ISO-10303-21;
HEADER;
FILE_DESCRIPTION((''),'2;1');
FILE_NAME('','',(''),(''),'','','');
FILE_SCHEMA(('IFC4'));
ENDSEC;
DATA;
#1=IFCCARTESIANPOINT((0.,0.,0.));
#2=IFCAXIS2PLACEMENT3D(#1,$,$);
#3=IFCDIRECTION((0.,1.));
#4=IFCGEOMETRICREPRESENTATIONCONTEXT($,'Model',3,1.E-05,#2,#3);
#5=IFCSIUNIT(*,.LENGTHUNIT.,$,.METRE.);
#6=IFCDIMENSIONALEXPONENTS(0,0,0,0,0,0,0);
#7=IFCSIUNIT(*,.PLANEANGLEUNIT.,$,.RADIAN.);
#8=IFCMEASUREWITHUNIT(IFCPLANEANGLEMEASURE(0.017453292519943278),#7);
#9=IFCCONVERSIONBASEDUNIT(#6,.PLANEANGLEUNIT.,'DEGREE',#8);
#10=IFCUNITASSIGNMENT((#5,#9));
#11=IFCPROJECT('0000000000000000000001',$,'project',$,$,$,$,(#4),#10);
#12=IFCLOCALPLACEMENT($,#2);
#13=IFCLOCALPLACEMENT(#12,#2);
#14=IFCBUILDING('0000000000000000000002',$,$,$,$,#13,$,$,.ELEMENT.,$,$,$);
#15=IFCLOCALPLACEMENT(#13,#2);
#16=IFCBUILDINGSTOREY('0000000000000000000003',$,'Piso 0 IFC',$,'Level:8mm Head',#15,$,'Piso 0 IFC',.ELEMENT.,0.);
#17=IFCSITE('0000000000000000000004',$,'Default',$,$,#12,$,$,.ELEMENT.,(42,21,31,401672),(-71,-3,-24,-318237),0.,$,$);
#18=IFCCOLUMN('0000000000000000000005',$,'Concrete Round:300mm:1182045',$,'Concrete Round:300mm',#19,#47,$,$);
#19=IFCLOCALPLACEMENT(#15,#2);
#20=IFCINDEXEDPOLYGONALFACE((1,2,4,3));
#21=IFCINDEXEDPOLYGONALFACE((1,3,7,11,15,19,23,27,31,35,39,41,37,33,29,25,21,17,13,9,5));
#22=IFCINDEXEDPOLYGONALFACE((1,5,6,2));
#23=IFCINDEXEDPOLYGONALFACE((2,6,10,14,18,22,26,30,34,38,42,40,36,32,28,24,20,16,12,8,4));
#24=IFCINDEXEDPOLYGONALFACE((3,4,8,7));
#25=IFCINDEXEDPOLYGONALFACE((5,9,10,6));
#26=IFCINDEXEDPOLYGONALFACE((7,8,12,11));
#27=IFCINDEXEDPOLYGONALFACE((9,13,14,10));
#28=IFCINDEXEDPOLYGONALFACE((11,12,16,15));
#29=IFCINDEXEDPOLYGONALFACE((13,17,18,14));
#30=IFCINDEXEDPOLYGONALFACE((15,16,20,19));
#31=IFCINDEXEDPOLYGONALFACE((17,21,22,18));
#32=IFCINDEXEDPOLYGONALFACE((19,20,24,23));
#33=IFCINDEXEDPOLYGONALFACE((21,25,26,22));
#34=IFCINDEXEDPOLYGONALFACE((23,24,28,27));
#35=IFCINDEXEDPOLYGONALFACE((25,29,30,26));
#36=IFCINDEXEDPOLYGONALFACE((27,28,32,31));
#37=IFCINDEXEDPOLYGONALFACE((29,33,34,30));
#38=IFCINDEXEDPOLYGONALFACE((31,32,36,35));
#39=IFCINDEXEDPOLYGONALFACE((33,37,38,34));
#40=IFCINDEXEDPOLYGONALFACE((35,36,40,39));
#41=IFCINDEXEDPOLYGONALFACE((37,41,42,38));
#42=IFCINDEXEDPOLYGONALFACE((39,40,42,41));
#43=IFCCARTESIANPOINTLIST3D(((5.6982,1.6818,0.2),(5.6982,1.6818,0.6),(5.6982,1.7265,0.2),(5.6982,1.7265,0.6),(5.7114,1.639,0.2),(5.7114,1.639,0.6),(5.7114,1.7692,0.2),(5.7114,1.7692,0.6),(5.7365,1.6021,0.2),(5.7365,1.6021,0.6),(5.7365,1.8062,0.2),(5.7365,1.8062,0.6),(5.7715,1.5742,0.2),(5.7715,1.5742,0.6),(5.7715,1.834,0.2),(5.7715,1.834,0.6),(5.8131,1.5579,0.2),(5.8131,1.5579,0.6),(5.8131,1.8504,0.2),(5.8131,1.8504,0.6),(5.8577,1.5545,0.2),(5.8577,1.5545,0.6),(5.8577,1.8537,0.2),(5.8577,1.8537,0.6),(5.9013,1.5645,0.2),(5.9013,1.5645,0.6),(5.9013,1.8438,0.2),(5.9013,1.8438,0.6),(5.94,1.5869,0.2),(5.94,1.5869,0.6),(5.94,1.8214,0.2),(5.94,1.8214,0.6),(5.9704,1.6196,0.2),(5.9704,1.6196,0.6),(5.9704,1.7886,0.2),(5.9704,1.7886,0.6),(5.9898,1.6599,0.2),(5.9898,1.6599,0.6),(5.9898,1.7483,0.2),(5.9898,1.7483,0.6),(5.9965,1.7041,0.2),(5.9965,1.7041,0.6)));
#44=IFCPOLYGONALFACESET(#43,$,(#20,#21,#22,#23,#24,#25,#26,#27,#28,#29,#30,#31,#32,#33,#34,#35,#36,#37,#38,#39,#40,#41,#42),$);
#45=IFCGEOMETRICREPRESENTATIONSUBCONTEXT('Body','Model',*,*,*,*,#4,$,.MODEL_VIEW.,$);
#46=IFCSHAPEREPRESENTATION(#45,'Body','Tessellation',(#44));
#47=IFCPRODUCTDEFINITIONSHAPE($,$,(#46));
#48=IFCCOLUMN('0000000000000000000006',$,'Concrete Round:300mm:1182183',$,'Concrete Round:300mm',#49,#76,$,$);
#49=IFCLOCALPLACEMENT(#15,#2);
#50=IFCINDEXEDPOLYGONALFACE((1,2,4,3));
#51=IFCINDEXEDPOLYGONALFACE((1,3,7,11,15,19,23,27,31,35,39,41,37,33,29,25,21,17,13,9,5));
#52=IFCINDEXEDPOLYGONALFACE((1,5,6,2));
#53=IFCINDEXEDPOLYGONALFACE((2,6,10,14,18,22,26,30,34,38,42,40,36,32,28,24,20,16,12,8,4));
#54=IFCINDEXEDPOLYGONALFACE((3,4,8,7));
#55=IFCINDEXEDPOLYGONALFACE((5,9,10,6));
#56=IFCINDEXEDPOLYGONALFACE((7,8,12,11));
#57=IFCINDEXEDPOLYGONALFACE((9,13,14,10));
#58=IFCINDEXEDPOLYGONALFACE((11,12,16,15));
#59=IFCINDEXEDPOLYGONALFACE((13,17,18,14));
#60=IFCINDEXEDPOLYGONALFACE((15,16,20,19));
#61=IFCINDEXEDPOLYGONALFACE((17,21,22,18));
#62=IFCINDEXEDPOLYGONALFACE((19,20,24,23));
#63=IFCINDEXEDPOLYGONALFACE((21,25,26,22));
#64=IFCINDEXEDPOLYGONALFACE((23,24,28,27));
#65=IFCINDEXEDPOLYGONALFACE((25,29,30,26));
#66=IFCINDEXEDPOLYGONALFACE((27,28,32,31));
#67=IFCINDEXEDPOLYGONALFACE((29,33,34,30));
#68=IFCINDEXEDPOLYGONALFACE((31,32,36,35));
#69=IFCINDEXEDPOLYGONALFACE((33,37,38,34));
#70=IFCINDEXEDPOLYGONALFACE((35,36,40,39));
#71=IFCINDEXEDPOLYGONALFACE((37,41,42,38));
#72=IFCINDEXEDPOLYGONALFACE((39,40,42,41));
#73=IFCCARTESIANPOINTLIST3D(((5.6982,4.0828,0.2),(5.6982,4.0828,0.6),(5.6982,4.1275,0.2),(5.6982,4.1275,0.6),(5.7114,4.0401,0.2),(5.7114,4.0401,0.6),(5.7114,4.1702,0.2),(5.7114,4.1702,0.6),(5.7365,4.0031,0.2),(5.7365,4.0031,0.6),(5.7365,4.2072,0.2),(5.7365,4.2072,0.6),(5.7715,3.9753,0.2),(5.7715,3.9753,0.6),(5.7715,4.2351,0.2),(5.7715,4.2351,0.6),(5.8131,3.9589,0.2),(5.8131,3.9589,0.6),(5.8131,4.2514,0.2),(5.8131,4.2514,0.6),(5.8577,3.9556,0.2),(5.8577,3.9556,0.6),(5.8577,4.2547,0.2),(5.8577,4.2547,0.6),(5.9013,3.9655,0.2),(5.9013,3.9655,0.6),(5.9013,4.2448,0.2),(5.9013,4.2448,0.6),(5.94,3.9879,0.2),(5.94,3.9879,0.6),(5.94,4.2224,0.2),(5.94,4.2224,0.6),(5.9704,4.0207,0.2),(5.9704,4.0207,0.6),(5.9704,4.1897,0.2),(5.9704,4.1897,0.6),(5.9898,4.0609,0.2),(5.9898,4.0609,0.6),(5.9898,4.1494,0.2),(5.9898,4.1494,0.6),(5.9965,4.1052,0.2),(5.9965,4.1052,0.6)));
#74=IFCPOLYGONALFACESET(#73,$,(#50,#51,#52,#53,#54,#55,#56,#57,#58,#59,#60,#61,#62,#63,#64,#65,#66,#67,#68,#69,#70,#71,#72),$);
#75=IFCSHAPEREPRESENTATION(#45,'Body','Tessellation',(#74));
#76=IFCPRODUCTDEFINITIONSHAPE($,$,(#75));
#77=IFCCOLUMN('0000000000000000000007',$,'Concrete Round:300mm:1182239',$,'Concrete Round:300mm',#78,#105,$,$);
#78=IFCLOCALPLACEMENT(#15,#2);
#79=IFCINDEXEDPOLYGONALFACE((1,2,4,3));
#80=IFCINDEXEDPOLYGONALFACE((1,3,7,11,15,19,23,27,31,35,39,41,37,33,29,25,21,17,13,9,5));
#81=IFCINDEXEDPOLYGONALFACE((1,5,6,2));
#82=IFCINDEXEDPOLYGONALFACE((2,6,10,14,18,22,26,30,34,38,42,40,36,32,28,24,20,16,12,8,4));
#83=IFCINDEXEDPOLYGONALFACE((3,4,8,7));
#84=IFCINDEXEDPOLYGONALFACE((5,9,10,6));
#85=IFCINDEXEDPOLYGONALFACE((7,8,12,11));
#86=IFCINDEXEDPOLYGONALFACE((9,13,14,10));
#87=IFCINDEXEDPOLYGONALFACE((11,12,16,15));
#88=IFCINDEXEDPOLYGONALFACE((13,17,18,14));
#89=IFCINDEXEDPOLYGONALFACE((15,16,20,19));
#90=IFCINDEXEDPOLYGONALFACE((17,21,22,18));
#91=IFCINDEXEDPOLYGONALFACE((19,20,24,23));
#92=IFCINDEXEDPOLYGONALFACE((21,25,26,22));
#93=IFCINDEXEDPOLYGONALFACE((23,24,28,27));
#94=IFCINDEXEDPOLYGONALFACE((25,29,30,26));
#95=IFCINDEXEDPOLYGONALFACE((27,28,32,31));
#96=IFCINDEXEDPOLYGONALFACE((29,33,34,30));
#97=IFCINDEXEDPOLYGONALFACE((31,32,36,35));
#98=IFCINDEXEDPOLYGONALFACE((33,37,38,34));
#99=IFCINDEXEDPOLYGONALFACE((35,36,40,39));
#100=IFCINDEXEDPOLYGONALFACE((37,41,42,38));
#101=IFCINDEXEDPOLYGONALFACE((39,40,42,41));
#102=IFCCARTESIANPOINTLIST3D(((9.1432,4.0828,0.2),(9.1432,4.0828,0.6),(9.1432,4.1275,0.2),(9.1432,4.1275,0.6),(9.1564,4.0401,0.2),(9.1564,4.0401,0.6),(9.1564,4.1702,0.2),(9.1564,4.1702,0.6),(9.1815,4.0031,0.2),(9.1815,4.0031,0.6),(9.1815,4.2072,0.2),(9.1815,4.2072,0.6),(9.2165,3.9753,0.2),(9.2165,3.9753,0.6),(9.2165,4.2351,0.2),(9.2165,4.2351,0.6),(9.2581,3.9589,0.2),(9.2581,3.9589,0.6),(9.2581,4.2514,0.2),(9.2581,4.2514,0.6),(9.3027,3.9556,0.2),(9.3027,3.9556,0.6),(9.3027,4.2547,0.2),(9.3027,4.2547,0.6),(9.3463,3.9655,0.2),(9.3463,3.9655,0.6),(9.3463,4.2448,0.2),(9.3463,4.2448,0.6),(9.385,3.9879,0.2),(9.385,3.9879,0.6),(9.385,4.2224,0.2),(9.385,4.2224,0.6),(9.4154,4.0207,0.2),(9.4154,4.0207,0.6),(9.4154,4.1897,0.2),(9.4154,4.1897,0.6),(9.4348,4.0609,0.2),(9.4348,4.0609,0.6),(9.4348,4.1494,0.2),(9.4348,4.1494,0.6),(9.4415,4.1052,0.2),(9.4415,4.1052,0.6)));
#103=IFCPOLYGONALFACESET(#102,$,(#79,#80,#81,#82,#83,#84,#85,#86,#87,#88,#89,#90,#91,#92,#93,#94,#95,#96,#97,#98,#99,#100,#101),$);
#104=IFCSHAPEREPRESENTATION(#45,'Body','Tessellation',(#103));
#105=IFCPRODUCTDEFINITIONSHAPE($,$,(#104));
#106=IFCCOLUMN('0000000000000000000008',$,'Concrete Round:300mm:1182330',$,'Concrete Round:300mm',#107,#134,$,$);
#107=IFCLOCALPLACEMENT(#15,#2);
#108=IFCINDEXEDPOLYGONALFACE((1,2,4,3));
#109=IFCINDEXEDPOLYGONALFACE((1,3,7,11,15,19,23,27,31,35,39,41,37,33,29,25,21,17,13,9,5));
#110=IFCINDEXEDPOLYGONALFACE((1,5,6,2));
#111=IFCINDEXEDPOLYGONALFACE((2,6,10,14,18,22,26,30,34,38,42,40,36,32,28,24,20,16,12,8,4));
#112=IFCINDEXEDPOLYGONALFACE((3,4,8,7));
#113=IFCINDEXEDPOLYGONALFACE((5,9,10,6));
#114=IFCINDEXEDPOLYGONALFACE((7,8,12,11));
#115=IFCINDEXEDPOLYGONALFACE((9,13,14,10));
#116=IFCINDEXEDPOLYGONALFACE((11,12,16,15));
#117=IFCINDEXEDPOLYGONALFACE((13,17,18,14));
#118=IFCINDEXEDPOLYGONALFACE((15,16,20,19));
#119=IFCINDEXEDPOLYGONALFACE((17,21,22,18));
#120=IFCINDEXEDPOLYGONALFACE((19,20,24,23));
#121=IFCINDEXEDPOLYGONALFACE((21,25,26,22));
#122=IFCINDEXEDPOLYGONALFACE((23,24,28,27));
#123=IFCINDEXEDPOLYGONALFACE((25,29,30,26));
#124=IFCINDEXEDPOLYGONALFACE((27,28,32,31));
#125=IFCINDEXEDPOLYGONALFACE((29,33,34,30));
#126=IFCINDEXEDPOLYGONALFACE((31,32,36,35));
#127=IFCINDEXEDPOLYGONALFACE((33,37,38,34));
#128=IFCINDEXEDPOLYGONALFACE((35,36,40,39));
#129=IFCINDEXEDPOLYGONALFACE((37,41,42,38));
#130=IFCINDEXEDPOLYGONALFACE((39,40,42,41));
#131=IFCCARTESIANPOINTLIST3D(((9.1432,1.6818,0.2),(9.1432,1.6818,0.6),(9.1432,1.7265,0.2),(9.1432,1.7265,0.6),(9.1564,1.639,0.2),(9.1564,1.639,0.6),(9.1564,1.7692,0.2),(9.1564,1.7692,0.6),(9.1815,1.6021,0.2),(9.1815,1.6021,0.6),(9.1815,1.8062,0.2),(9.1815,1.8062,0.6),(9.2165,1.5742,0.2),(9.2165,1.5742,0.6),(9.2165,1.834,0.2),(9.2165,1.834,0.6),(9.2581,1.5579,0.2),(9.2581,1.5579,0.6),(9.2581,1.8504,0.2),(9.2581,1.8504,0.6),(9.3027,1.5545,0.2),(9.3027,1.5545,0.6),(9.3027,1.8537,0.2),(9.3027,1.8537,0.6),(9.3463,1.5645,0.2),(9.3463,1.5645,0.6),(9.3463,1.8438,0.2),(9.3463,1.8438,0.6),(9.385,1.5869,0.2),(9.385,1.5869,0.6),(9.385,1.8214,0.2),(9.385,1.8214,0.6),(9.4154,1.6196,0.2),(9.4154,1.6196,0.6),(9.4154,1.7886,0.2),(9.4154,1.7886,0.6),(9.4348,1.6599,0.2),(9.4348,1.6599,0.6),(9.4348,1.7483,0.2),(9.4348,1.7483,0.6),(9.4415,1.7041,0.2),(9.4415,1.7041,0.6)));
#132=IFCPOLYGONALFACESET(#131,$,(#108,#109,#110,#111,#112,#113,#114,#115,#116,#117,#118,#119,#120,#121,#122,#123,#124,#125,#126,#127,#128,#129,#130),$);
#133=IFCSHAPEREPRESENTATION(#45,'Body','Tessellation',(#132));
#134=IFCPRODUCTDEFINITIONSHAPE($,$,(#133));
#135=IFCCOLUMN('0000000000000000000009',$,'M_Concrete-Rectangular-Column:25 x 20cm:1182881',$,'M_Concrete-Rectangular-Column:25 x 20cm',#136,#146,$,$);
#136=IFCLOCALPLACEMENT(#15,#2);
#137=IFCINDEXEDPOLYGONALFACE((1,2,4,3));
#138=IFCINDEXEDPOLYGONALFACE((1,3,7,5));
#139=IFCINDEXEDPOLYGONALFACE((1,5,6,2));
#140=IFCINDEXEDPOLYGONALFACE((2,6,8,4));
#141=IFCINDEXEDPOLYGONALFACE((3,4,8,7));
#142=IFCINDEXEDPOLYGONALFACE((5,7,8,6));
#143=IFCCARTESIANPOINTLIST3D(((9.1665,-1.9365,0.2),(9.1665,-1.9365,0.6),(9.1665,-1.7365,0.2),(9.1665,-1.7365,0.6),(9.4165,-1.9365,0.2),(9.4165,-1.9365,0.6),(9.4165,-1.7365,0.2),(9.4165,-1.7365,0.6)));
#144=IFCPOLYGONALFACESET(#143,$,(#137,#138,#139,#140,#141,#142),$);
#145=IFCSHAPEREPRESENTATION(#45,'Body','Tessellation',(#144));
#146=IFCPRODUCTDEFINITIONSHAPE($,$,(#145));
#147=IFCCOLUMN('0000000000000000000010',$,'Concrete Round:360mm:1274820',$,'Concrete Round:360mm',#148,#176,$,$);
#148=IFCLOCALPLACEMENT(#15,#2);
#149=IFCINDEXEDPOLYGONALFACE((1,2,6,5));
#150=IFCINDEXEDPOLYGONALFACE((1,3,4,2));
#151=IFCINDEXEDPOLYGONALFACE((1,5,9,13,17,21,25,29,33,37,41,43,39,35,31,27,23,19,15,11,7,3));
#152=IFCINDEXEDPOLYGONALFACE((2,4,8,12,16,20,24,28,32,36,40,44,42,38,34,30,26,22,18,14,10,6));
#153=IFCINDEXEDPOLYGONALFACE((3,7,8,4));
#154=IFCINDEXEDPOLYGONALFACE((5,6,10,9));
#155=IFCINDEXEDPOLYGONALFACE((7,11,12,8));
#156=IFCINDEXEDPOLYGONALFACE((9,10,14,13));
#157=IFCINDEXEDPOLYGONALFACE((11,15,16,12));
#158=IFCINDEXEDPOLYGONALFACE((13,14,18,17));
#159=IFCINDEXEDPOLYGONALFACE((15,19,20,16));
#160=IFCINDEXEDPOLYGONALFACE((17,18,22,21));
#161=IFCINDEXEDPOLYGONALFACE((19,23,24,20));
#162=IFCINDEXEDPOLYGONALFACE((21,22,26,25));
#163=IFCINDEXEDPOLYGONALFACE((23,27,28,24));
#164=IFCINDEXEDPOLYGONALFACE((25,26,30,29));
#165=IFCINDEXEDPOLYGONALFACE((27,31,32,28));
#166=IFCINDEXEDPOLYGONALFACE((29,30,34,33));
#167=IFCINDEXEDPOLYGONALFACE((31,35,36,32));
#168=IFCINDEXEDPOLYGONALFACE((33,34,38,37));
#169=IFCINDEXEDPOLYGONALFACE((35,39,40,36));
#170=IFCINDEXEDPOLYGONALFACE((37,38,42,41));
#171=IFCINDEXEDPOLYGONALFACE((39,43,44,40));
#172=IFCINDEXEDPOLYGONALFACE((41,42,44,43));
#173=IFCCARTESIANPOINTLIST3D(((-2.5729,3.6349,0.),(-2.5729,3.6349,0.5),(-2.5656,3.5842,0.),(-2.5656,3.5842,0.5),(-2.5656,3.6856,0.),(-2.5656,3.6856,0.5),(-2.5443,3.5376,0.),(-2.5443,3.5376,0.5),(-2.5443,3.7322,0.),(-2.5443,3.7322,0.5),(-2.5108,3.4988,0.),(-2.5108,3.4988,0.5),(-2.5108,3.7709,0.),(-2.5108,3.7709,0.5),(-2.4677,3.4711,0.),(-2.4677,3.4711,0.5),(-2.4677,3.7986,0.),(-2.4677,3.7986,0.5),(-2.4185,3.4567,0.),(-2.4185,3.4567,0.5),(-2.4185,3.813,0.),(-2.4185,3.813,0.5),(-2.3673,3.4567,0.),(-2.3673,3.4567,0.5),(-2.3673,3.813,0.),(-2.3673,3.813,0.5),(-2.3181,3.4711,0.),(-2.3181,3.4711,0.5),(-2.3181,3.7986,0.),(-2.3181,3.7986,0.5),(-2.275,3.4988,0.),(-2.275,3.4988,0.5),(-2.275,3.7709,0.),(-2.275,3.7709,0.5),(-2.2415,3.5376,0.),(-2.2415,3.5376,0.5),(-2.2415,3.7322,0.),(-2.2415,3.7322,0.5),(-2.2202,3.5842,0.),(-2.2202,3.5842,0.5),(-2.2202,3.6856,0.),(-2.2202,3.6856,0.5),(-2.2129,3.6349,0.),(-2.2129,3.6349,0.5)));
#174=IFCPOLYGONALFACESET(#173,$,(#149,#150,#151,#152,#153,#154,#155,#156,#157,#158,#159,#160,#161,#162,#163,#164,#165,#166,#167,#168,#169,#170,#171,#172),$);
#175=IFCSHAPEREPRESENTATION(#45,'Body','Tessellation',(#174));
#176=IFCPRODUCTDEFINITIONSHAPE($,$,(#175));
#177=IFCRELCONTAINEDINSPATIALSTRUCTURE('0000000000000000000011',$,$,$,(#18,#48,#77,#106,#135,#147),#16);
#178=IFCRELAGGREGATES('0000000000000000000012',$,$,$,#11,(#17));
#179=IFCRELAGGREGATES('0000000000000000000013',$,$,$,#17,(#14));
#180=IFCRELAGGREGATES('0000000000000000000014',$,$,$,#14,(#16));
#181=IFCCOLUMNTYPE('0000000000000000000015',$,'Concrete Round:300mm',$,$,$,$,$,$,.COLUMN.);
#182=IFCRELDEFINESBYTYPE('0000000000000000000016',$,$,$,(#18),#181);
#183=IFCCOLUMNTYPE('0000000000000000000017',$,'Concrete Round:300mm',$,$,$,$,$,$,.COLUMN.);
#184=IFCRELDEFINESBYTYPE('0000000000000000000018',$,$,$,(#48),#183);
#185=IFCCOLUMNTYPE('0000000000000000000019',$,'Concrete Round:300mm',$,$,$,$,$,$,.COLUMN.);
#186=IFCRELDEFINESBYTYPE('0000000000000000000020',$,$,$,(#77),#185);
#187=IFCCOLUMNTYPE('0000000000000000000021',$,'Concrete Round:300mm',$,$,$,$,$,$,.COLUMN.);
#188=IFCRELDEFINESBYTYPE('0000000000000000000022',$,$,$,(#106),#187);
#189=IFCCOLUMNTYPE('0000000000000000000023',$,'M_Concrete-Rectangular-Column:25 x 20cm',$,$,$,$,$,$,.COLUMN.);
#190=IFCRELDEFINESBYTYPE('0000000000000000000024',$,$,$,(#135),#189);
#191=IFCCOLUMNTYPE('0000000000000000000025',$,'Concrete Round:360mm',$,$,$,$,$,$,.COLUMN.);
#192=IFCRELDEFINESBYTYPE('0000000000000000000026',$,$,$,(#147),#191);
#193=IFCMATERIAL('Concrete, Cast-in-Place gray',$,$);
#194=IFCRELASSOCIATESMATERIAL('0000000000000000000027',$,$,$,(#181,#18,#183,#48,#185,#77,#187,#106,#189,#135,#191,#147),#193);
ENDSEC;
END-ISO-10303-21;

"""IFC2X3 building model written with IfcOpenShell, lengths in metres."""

from ifc_helpers import new_model, entity, si_unit, converted_unit, direction, frame, frame_2d, origin, origin_2d_with_axis, place, context, subcontext, project, spatial, rectangle, circle, extrude, source, transform, mapped, material, type_object, type_shapes, element, save


model = new_model("IFC2X3")

# Units and contexts
model_context = context("Model", 3, precision=1e-05, world=origin(), true_north=direction((0.0, 1.0)))
body_context = subcontext(model_context, "Body", "Model", "MODEL_VIEW")
ifc_project = project(units=[si_unit("LENGTHUNIT", "METRE"), converted_unit("PLANEANGLEUNIT", "DEGREE", entity("IfcPlaneAngleMeasure", 0.017453292519943278), si_unit("PLANEANGLEUNIT", "RADIAN"), dimensions=[0, 0, 0, 0, 0, 0, 0])], contexts=[model_context])

# Site, building, storey
site_placement = place(None, origin())
site = spatial("IfcSite", under=ifc_project, at=site_placement, Name="Default", CompositionType="ELEMENT", RefLatitude=(42, 21, 31, 401672), RefLongitude=(-71, -3, -24, -318237), RefElevation=0.0)
building_placement = place(site_placement, origin())
building = spatial("IfcBuilding", under=site, at=building_placement, CompositionType="ELEMENT")
storey_placement = place(building_placement, origin())
storey = spatial("IfcBuildingStorey", under=building, at=storey_placement, Name="Piso 0 IFC", ObjectType="Level:8mm Head", LongName="Piso 0 IFC", CompositionType="ELEMENT", Elevation=0.0)

# Columns
ifc_material_1 = material(Name="Concrete, Cast-in-Place gray")
column_type_1 = type_object("IfcColumnType", Name="Concrete Round:300mm", PredefinedType="COLUMN", material=ifc_material_1)
shared_shape_1 = source(origin(), body_context, "Body", "SweptSolid", [
    extrude(circle(Radius=0.15, at=frame_2d((0.0, 0.0), x_axis=(1.0, 0.0))), frame((5.8465, 1.7041, 0.2)), (0.0, 0.0, 1.0), 0.4),
])
type_shapes(column_type_1, [shared_shape_1])
column_1_placement = place(storey_placement, origin())
element("IfcColumn", 1, at=column_1_placement, inside=storey, type_object=column_type_1, material=ifc_material_1, Name="Concrete Round:300mm:1182045", ObjectType="Concrete Round:300mm", context=body_context, shape_type="MappedRepresentation", body=[
    mapped(shared_shape_1, transform((0.0, 0.0, 0.0), scale=1.0)),
])
column_type_2 = type_object("IfcColumnType", Name="Concrete Round:300mm", PredefinedType="COLUMN", material=ifc_material_1)
shared_shape_2 = source(origin(), body_context, "Body", "SweptSolid", [
    extrude(circle(Radius=0.15, at=frame_2d((0.0, 0.0), x_axis=(1.0, 0.0))), frame((5.8465, 4.1052, 0.2)), (0.0, 0.0, 1.0), 0.4),
])
type_shapes(column_type_2, [shared_shape_2])
column_2_placement = place(storey_placement, origin())
element("IfcColumn", 2, at=column_2_placement, inside=storey, type_object=column_type_2, material=ifc_material_1, Name="Concrete Round:300mm:1182183", ObjectType="Concrete Round:300mm", context=body_context, shape_type="MappedRepresentation", body=[
    mapped(shared_shape_2, transform((0.0, 0.0, 0.0), scale=1.0)),
])
column_type_3 = type_object("IfcColumnType", Name="Concrete Round:300mm", PredefinedType="COLUMN", material=ifc_material_1)
shared_shape_3 = source(origin(), body_context, "Body", "SweptSolid", [
    extrude(circle(Radius=0.15, at=origin_2d_with_axis()), frame((9.2915, 4.1052, 0.2)), (0.0, 0.0, 1.0), 0.4),
])
type_shapes(column_type_3, [shared_shape_3])
column_3_placement = place(storey_placement, origin())
element("IfcColumn", 3, at=column_3_placement, inside=storey, type_object=column_type_3, material=ifc_material_1, Name="Concrete Round:300mm:1182239", ObjectType="Concrete Round:300mm", context=body_context, shape_type="MappedRepresentation", body=[
    mapped(shared_shape_3, transform((0.0, 0.0, 0.0), scale=1.0)),
])
column_type_4 = type_object("IfcColumnType", Name="Concrete Round:300mm", PredefinedType="COLUMN", material=ifc_material_1)
shared_shape_4 = source(origin(), body_context, "Body", "SweptSolid", [
    extrude(circle(Radius=0.15, at=frame_2d((0.0, 0.0), x_axis=(1.0, 0.0))), frame((9.2915, 1.7041, 0.2)), (0.0, 0.0, 1.0), 0.4),
])
type_shapes(column_type_4, [shared_shape_4])
column_4_placement = place(storey_placement, origin())
element("IfcColumn", 4, at=column_4_placement, inside=storey, type_object=column_type_4, material=ifc_material_1, Name="Concrete Round:300mm:1182330", ObjectType="Concrete Round:300mm", context=body_context, shape_type="MappedRepresentation", body=[
    mapped(shared_shape_4, transform((0.0, 0.0, 0.0), scale=1.0)),
])
column_type_5 = type_object("IfcColumnType", Name="M_Concrete-Rectangular-Column:25 x 20cm", PredefinedType="COLUMN", material=ifc_material_1)
shared_shape_5 = source(origin(), body_context, "Body", "SweptSolid", [
    extrude(rectangle(XDim=0.4, YDim=0.2, at=origin_2d_with_axis()), frame((9.1665, -1.8365, 0.4), z_axis=(1.0, 0.0, 0.0), x_axis=(0.0, 0.0, -1.0)), (0.0, 0.0, 1.0), 0.25),
])
type_shapes(column_type_5, [shared_shape_5])
column_5_placement = place(storey_placement, origin())
element("IfcColumn", 5, at=column_5_placement, inside=storey, type_object=column_type_5, material=ifc_material_1, Name="M_Concrete-Rectangular-Column:25 x 20cm:1182881", ObjectType="M_Concrete-Rectangular-Column:25 x 20cm", context=body_context, shape_type="MappedRepresentation", body=[
    mapped(shared_shape_5, transform((0.0, 0.0, 0.0), scale=1.0)),
])
column_type_6 = type_object("IfcColumnType", Name="Concrete Round:360mm", PredefinedType="COLUMN", material=ifc_material_1)
shared_shape_6 = source(origin(), body_context, "Body", "SweptSolid", [
    extrude(circle(Radius=0.18, at=origin_2d_with_axis()), frame((-2.3929, 3.6349, 0.0)), (0.0, 0.0, 1.0), 0.5),
])
type_shapes(column_type_6, [shared_shape_6])
column_6_placement = place(storey_placement, origin())
element("IfcColumn", 6, at=column_6_placement, inside=storey, type_object=column_type_6, material=ifc_material_1, Name="Concrete Round:360mm:1274820", ObjectType="Concrete Round:360mm", context=body_context, shape_type="MappedRepresentation", body=[
    mapped(shared_shape_6, transform((0.0, 0.0, 0.0), scale=1.0)),
])

save(model, "model.ifc")
